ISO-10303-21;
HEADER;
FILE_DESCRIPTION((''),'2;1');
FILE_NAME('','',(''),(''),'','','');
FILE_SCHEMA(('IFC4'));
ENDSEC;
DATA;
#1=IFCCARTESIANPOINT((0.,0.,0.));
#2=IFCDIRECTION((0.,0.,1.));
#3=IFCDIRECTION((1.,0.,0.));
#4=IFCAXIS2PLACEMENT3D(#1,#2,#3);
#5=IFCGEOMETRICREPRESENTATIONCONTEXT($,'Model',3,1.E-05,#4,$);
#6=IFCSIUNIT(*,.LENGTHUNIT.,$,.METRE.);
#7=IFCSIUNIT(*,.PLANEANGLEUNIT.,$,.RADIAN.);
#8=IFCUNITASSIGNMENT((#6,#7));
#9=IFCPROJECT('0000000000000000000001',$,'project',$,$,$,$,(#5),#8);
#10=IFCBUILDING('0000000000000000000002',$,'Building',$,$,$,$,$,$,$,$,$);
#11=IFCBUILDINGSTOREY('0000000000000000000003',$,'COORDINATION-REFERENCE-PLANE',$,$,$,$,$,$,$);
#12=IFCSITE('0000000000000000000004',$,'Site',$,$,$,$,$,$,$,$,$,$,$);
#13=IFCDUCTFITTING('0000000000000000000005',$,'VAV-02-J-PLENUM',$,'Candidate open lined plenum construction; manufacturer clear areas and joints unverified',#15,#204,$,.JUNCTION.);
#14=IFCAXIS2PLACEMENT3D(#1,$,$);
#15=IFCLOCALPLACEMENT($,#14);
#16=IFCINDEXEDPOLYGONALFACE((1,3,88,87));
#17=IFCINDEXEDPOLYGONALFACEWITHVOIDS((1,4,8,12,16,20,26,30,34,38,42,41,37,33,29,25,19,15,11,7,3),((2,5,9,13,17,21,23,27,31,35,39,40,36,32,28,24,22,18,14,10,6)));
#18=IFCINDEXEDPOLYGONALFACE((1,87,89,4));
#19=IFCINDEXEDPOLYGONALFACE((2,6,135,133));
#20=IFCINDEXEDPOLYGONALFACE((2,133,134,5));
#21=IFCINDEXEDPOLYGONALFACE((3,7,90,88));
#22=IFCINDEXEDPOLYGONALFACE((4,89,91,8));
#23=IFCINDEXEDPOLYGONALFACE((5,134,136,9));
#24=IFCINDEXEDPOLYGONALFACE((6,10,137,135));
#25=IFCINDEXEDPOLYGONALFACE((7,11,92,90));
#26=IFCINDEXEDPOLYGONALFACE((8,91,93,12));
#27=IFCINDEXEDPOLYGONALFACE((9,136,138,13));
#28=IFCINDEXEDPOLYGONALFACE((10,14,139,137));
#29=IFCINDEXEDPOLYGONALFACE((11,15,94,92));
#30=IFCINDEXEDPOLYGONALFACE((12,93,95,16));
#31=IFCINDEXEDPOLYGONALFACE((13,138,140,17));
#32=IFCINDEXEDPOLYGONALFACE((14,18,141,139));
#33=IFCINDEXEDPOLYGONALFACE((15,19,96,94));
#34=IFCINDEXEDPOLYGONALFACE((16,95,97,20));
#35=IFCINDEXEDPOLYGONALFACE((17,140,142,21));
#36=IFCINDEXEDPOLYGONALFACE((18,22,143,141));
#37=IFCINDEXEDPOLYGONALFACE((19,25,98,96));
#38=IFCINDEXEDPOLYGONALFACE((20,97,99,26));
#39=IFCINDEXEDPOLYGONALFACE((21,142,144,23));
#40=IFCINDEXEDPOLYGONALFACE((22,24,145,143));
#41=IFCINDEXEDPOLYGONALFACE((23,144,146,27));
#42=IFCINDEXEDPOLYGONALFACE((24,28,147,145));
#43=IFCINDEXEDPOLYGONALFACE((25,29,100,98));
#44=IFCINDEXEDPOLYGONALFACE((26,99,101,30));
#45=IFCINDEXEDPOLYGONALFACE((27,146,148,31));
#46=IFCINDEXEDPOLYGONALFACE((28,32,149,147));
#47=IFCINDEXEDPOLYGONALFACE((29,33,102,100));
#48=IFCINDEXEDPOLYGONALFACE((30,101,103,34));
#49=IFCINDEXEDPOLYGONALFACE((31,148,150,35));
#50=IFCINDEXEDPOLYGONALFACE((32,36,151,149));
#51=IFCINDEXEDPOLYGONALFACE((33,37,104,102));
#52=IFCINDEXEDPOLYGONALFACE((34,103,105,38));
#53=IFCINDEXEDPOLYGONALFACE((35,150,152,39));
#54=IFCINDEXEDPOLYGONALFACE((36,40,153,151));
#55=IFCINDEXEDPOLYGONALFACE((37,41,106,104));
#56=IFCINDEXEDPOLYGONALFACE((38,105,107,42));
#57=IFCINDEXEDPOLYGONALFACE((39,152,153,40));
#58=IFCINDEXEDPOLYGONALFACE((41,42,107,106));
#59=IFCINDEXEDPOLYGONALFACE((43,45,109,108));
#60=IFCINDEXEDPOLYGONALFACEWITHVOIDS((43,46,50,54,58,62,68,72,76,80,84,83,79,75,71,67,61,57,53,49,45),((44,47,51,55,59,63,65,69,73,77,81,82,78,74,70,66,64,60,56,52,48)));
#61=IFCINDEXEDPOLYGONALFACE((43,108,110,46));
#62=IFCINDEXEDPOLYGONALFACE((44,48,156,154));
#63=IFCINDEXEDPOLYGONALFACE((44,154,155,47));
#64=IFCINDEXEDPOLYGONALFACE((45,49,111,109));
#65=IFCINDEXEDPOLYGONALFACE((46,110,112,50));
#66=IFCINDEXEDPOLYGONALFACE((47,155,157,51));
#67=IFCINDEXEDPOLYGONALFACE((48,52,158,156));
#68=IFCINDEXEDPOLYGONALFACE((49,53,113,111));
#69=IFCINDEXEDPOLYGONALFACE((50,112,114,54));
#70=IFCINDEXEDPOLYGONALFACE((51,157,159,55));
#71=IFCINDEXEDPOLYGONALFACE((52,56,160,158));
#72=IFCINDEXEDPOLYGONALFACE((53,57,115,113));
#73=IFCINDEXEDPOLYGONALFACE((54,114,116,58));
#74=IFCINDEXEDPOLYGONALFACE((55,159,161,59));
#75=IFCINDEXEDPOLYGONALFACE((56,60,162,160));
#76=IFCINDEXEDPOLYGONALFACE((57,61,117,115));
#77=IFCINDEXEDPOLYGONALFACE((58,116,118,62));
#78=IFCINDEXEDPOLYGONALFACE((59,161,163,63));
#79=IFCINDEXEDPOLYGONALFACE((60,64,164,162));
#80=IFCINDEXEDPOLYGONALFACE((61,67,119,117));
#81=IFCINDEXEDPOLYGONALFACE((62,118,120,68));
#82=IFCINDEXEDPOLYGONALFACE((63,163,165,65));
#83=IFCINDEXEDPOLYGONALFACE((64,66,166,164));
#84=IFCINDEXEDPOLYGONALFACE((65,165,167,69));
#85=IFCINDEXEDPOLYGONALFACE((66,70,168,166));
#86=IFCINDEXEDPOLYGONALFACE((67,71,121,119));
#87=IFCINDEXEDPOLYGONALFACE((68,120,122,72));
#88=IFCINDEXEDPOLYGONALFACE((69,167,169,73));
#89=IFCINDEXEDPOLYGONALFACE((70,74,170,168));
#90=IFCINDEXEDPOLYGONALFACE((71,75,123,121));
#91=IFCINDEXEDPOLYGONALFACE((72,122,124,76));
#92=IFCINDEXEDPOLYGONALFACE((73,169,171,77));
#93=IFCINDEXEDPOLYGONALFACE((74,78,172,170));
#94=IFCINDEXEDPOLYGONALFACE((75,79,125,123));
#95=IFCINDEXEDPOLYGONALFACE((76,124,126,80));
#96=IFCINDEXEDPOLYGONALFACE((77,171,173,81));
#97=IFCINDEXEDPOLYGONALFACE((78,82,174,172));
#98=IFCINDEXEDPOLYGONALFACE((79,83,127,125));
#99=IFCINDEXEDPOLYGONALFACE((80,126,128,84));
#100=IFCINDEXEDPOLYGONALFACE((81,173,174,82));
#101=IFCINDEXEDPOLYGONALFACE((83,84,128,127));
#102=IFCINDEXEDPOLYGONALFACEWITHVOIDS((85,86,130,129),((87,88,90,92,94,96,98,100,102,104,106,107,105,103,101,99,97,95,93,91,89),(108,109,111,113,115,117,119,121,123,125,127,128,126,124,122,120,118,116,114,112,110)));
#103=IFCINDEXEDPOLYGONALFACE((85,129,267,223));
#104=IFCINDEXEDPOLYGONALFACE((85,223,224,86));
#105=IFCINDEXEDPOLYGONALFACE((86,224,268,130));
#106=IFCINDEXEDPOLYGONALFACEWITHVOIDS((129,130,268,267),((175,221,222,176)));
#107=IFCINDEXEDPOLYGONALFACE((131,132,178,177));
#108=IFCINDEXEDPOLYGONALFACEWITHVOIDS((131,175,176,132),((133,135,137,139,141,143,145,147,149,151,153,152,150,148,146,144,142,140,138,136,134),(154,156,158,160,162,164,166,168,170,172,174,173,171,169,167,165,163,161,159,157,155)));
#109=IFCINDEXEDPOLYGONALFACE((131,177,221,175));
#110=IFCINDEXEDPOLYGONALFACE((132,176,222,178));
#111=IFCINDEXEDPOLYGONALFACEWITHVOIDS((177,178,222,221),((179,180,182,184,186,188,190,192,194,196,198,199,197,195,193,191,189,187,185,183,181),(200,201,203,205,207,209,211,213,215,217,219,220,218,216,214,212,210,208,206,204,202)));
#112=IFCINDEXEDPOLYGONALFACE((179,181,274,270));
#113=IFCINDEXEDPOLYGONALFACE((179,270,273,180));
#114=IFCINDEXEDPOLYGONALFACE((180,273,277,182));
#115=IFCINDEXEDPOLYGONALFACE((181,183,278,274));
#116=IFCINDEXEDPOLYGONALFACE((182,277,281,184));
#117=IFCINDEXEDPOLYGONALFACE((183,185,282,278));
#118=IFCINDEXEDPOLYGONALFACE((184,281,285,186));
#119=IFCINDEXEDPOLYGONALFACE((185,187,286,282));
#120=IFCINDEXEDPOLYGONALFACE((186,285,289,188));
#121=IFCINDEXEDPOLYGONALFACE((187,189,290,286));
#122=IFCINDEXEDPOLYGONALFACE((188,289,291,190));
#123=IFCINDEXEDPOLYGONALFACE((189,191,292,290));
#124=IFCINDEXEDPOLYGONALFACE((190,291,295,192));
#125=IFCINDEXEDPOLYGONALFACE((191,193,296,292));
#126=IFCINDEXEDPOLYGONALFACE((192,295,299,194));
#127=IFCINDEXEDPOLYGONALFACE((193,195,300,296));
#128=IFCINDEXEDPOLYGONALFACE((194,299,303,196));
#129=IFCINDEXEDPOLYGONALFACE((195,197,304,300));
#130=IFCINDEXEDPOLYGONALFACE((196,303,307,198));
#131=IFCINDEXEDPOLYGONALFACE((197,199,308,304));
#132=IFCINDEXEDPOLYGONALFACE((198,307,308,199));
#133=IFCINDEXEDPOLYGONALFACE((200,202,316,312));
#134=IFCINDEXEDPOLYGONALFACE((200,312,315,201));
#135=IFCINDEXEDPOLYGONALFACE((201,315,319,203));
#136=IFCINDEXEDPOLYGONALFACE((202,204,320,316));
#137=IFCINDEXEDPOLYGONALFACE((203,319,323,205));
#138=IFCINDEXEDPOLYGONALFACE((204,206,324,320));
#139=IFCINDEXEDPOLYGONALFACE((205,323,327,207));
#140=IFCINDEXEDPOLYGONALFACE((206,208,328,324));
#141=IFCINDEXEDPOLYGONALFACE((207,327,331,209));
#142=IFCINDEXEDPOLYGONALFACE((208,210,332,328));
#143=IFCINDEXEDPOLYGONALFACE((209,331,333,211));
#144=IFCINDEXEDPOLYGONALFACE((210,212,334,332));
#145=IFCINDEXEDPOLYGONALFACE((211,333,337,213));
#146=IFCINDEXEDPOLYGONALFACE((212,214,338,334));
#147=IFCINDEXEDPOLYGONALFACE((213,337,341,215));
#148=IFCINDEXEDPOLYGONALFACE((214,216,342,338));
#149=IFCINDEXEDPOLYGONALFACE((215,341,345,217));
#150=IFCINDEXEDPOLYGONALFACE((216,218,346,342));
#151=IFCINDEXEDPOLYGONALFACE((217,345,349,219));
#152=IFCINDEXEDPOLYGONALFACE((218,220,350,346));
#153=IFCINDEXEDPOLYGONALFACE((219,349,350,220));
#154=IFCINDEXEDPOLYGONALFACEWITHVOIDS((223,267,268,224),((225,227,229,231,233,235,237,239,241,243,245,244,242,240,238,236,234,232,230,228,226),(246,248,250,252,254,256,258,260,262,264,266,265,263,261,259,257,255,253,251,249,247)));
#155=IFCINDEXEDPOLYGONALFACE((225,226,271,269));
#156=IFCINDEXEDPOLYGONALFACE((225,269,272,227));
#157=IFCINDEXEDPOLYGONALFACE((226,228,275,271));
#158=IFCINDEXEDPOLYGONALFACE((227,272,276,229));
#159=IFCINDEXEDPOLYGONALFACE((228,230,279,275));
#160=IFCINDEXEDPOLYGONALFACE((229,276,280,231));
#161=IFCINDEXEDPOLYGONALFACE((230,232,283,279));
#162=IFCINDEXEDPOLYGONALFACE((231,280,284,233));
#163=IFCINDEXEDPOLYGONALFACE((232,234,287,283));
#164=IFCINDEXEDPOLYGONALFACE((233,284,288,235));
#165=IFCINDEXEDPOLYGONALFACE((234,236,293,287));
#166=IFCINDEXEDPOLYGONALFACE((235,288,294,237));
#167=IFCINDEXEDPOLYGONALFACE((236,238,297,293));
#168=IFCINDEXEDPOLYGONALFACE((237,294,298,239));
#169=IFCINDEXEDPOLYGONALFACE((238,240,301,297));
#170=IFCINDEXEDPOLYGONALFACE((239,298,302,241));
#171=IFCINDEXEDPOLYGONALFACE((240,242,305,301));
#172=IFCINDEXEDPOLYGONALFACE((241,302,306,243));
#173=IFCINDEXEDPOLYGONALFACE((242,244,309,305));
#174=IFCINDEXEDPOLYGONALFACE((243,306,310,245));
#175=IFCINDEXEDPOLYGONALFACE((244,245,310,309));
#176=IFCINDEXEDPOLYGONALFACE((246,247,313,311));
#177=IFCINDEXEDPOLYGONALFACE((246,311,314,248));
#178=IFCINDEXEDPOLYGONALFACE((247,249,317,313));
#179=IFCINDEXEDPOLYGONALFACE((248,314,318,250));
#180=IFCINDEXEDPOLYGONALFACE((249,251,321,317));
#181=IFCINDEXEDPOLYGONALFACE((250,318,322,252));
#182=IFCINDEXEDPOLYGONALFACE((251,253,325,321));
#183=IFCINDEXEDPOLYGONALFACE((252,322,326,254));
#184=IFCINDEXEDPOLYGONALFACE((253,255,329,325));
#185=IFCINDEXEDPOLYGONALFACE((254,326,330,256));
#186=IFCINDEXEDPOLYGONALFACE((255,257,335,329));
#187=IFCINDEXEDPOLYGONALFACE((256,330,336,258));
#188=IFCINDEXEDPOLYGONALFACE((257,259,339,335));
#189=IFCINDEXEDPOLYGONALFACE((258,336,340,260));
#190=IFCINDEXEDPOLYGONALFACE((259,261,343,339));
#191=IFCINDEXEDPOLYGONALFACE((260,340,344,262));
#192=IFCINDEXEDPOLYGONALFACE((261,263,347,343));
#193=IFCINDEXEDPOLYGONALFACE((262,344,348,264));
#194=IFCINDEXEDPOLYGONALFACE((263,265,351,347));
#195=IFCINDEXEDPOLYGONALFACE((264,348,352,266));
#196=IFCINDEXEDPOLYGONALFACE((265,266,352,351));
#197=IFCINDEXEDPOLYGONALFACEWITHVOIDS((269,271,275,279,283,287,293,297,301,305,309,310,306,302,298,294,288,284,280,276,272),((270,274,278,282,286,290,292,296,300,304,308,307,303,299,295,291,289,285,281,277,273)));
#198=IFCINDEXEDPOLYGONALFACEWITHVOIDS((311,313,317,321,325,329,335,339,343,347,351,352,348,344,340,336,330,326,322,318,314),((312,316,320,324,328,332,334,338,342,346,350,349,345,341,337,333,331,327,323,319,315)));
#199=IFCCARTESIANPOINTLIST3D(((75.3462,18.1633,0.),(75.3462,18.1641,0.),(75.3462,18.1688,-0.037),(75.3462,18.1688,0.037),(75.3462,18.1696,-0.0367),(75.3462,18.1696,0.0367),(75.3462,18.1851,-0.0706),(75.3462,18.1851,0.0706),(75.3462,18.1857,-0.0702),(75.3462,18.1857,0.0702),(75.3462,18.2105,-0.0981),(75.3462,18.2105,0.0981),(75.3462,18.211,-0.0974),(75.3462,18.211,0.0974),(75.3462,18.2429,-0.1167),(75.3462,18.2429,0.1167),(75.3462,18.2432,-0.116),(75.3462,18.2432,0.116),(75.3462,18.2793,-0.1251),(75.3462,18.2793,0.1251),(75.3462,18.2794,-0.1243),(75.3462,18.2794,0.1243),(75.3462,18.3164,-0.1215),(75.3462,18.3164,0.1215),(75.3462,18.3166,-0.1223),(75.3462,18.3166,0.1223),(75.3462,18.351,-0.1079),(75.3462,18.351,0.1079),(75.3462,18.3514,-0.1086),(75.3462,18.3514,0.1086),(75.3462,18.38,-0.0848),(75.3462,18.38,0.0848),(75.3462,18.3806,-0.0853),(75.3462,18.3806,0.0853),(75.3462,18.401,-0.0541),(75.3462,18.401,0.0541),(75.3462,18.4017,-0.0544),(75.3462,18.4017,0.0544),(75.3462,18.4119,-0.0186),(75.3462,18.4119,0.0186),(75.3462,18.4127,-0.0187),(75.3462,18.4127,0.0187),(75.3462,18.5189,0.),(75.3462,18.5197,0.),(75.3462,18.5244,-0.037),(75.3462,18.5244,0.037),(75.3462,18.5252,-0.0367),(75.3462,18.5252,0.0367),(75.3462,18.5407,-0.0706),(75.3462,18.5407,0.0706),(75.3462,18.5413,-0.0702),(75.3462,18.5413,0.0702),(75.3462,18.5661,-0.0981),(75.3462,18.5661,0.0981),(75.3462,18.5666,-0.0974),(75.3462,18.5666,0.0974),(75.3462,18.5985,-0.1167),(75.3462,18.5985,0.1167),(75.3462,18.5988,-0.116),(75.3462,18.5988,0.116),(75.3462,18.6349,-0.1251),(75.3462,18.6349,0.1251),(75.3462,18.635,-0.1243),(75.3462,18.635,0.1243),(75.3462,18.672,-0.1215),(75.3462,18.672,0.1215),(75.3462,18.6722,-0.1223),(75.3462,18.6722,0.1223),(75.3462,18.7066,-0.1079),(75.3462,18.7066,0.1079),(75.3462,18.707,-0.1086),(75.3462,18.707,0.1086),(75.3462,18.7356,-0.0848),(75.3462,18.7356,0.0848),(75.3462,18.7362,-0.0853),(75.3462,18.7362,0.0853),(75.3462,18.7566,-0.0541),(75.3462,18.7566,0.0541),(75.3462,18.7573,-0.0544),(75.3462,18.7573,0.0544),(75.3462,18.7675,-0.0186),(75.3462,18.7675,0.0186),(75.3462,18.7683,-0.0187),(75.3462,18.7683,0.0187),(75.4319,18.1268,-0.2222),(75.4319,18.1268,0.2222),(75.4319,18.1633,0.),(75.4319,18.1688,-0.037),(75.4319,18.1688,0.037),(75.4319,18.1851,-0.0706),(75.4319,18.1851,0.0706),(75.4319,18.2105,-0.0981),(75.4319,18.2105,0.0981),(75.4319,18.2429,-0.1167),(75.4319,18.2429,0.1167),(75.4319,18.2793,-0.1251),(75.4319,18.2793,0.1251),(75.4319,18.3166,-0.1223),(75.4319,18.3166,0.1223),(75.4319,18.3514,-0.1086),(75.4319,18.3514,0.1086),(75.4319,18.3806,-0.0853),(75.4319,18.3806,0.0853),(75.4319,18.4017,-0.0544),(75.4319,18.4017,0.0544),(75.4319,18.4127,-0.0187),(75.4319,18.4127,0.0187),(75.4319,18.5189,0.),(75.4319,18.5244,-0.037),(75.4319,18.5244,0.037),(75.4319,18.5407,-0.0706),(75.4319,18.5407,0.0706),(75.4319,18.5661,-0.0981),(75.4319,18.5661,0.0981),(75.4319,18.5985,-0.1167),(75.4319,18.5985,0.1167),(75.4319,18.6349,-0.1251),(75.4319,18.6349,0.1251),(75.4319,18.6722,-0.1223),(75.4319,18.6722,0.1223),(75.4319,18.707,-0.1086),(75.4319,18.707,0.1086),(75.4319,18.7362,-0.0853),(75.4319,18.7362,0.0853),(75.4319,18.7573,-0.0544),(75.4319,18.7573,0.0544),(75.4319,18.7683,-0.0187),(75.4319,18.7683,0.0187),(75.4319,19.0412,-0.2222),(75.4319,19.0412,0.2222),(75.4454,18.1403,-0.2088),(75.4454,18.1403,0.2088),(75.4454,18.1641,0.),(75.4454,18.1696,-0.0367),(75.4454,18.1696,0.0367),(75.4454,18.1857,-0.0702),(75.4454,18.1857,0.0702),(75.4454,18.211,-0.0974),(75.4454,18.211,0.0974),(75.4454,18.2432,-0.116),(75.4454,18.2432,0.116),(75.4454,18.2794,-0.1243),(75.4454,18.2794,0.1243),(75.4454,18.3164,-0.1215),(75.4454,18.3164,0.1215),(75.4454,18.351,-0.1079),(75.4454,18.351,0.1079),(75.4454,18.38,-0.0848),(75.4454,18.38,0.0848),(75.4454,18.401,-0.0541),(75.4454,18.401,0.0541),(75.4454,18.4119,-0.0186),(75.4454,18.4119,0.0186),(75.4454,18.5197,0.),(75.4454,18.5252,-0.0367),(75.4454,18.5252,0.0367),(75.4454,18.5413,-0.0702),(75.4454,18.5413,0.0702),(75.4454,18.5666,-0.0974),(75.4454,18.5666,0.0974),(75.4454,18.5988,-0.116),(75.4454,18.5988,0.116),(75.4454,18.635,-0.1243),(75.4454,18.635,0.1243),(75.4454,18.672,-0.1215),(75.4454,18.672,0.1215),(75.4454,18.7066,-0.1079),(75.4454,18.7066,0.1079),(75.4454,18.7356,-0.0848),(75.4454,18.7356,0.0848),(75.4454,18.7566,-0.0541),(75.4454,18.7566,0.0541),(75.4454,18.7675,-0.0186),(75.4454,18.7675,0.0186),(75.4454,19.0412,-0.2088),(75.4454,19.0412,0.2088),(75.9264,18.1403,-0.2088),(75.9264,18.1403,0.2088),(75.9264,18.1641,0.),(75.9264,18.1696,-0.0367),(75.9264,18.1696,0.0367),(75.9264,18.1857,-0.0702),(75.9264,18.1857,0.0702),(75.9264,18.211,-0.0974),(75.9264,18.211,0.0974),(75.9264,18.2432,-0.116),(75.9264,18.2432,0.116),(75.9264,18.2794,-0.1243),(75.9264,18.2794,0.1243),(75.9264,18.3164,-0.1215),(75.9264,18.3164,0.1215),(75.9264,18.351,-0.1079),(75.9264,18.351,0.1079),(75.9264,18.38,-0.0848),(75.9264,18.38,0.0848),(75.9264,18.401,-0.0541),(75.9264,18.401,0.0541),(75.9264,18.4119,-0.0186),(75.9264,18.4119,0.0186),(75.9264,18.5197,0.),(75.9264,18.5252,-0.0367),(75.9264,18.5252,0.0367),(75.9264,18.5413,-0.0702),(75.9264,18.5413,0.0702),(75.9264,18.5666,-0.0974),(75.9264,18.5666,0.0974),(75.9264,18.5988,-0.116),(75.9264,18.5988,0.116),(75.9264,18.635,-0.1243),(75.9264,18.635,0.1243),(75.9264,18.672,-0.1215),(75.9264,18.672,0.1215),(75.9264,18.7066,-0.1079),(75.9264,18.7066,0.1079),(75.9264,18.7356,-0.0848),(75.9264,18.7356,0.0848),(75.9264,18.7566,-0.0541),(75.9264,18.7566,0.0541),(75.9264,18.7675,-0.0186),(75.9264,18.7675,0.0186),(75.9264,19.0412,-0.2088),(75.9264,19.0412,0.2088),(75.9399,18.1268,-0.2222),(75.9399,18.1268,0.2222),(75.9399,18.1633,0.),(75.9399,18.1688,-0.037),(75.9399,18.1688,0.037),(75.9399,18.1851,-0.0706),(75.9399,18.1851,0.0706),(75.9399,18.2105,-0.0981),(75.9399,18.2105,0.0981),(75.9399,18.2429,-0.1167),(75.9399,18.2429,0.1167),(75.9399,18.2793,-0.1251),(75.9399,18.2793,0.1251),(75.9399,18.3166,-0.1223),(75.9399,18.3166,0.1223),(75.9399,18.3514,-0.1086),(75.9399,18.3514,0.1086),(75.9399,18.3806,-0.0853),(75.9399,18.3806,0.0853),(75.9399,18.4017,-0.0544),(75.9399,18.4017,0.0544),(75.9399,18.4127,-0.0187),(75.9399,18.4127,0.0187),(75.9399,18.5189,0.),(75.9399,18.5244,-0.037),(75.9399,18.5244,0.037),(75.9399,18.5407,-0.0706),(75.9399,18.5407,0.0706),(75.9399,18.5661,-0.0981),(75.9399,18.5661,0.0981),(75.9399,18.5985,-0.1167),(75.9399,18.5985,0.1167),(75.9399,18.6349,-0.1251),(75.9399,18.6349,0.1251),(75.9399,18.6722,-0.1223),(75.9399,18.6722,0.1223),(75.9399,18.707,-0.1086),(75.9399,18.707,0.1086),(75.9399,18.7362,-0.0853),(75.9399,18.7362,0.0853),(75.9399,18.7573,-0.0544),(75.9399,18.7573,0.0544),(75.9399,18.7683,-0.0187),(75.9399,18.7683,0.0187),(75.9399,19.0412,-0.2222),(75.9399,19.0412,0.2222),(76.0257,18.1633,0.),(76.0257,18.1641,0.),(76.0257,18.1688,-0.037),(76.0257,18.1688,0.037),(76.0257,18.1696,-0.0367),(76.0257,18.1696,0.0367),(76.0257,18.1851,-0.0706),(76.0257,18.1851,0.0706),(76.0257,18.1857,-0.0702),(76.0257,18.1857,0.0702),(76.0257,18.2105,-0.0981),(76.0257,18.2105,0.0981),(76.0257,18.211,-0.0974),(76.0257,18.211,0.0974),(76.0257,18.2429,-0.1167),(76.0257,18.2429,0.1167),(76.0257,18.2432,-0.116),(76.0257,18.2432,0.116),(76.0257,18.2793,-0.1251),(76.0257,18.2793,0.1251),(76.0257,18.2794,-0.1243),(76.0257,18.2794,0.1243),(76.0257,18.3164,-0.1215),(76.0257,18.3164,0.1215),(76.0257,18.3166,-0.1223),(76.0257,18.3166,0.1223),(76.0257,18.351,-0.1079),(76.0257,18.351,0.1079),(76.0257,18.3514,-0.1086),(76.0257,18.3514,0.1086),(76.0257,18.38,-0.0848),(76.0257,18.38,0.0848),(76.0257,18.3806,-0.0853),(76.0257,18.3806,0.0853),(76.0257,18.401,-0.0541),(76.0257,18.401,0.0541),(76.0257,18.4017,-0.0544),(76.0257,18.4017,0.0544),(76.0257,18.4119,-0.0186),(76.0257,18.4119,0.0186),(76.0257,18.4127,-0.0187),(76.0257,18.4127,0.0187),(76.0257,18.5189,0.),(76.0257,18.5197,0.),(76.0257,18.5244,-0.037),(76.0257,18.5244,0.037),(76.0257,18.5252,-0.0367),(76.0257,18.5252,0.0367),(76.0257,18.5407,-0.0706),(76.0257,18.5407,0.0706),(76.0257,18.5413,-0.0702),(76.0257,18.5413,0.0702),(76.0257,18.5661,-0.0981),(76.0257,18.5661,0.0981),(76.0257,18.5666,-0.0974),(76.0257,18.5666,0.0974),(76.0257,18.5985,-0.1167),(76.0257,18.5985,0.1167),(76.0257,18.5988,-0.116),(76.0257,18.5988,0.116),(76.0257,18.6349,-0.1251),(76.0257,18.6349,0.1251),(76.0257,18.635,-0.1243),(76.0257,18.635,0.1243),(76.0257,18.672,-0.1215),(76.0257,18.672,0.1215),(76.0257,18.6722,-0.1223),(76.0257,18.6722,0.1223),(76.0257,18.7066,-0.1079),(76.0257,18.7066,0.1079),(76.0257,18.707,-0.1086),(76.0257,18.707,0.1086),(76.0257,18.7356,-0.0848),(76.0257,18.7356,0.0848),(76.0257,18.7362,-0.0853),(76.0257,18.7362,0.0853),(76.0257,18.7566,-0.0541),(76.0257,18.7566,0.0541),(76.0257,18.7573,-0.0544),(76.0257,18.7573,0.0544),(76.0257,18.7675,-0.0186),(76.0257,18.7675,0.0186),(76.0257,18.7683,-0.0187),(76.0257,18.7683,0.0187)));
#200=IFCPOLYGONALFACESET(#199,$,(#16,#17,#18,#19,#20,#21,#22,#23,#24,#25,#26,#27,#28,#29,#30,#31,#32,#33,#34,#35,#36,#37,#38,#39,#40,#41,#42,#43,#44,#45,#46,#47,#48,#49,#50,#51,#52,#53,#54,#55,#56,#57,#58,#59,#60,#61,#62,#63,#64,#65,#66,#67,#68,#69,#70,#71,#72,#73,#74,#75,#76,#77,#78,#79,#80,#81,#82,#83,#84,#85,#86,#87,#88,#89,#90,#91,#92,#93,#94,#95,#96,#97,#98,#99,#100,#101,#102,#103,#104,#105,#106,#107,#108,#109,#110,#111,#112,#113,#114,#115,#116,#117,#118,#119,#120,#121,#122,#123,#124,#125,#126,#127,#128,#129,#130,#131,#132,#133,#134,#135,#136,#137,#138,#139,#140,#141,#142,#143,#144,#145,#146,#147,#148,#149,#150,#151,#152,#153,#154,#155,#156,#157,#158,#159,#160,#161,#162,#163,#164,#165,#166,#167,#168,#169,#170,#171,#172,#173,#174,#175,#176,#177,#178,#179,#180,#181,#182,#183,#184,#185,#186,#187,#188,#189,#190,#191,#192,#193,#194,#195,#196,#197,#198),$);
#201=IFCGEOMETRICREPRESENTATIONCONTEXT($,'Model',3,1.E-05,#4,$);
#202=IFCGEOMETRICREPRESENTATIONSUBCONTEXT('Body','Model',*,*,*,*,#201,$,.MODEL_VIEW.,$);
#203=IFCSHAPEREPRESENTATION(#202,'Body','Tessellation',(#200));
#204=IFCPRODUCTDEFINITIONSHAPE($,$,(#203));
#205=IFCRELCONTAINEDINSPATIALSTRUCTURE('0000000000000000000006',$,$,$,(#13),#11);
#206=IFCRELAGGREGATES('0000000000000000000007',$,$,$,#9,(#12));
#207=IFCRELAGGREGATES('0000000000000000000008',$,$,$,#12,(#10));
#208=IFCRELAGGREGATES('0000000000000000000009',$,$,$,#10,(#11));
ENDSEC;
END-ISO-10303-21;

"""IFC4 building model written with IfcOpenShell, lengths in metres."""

from ifc_helpers import new_model, si_unit, frame, origin_with_axes, place, context, subcontext, project, spatial, rectangle, circle, extrude, boolean, element, save


model = new_model("IFC4")

# Units and contexts
model_context_1 = context("Model", 3, precision=1e-05, world=origin_with_axes())
model_context_2 = context("Model", 3, precision=1e-05, world=origin_with_axes())
body_context_1 = subcontext(model_context_2, "Body", "Model", "MODEL_VIEW")
ifc_project = project(units=[si_unit("LENGTHUNIT", "METRE"), si_unit("PLANEANGLEUNIT", "RADIAN")], contexts=[model_context_1])

# Site, building, storey
site = spatial("IfcSite", under=ifc_project, Name="Site")
building = spatial("IfcBuilding", under=site, Name="Building")
storey = spatial("IfcBuildingStorey", under=building, Name="COORDINATION-REFERENCE-PLANE")

# Duct fitting
duct_fitting_1_placement = place(None, frame((75.4319, 18.1268, -0.2223), z_axis=(0.0, 0.0, 1.0), x_axis=(1.0, 0.0, 0.0)))
solid_1 = boolean("UNION", boolean("UNION", boolean("UNION", boolean("UNION", extrude(rectangle(XDim=0.481, YDim=0.4175), frame((0.254, 0.9244, 0.2223), z_axis=(0.0, -1.0, 0.0), x_axis=(1.0, 0.0, 0.0)), (0.0, 0.0, 1.0), 0.9109), extrude(circle(Radius=0.1246), frame((0.0235, 0.5175, 0.2223), z_axis=(-1.0, 0.0, 0.0), x_axis=(0.0, -1.0, 0.0)), (0.0, 0.0, 1.0), 0.1192)), extrude(circle(Radius=0.1246), frame((0.4845, 0.5175, 0.2223), z_axis=(1.0, 0.0, 0.0), x_axis=(0.0, -1.0, 0.0)), (0.0, 0.0, 1.0), 0.1192)), extrude(circle(Radius=0.1246), frame((0.0235, 0.1619, 0.2223), z_axis=(-1.0, 0.0, 0.0), x_axis=(0.0, -1.0, 0.0)), (0.0, 0.0, 1.0), 0.1192)), extrude(circle(Radius=0.1246), frame((0.4845, 0.1619, 0.2223), z_axis=(1.0, 0.0, 0.0), x_axis=(0.0, -1.0, 0.0)), (0.0, 0.0, 1.0), 0.1192))
element("IfcDuctFitting", 1, at=duct_fitting_1_placement, inside=storey, Name="VAV-02-J-PLENUM", ObjectType="Candidate open lined plenum construction; manufacturer clear areas and joints unverified", PredefinedType="JUNCTION", context=body_context_1, shape_type="CSG", body=[
    boolean("DIFFERENCE", boolean("UNION", boolean("UNION", boolean("UNION", boolean("UNION", extrude(rectangle(XDim=0.508, YDim=0.4445), frame((0.254, 0.9144, 0.2223), z_axis=(0.0, -1.0, 0.0), x_axis=(1.0, 0.0, 0.0)), (0.0, 0.0, 1.0), 0.9144), extrude(circle(Radius=0.1254), frame((0.0235, 0.5175, 0.2223), z_axis=(-1.0, 0.0, 0.0), x_axis=(0.0, -1.0, 0.0)), (0.0, 0.0, 1.0), 0.1092)), extrude(circle(Radius=0.1254), frame((0.4845, 0.5175, 0.2223), z_axis=(1.0, 0.0, 0.0), x_axis=(0.0, -1.0, 0.0)), (0.0, 0.0, 1.0), 0.1092)), extrude(circle(Radius=0.1254), frame((0.0235, 0.1619, 0.2223), z_axis=(-1.0, 0.0, 0.0), x_axis=(0.0, -1.0, 0.0)), (0.0, 0.0, 1.0), 0.1092)), extrude(circle(Radius=0.1254), frame((0.4845, 0.1619, 0.2223), z_axis=(1.0, 0.0, 0.0), x_axis=(0.0, -1.0, 0.0)), (0.0, 0.0, 1.0), 0.1092)), solid_1),
])

save(model, "model.ifc")
